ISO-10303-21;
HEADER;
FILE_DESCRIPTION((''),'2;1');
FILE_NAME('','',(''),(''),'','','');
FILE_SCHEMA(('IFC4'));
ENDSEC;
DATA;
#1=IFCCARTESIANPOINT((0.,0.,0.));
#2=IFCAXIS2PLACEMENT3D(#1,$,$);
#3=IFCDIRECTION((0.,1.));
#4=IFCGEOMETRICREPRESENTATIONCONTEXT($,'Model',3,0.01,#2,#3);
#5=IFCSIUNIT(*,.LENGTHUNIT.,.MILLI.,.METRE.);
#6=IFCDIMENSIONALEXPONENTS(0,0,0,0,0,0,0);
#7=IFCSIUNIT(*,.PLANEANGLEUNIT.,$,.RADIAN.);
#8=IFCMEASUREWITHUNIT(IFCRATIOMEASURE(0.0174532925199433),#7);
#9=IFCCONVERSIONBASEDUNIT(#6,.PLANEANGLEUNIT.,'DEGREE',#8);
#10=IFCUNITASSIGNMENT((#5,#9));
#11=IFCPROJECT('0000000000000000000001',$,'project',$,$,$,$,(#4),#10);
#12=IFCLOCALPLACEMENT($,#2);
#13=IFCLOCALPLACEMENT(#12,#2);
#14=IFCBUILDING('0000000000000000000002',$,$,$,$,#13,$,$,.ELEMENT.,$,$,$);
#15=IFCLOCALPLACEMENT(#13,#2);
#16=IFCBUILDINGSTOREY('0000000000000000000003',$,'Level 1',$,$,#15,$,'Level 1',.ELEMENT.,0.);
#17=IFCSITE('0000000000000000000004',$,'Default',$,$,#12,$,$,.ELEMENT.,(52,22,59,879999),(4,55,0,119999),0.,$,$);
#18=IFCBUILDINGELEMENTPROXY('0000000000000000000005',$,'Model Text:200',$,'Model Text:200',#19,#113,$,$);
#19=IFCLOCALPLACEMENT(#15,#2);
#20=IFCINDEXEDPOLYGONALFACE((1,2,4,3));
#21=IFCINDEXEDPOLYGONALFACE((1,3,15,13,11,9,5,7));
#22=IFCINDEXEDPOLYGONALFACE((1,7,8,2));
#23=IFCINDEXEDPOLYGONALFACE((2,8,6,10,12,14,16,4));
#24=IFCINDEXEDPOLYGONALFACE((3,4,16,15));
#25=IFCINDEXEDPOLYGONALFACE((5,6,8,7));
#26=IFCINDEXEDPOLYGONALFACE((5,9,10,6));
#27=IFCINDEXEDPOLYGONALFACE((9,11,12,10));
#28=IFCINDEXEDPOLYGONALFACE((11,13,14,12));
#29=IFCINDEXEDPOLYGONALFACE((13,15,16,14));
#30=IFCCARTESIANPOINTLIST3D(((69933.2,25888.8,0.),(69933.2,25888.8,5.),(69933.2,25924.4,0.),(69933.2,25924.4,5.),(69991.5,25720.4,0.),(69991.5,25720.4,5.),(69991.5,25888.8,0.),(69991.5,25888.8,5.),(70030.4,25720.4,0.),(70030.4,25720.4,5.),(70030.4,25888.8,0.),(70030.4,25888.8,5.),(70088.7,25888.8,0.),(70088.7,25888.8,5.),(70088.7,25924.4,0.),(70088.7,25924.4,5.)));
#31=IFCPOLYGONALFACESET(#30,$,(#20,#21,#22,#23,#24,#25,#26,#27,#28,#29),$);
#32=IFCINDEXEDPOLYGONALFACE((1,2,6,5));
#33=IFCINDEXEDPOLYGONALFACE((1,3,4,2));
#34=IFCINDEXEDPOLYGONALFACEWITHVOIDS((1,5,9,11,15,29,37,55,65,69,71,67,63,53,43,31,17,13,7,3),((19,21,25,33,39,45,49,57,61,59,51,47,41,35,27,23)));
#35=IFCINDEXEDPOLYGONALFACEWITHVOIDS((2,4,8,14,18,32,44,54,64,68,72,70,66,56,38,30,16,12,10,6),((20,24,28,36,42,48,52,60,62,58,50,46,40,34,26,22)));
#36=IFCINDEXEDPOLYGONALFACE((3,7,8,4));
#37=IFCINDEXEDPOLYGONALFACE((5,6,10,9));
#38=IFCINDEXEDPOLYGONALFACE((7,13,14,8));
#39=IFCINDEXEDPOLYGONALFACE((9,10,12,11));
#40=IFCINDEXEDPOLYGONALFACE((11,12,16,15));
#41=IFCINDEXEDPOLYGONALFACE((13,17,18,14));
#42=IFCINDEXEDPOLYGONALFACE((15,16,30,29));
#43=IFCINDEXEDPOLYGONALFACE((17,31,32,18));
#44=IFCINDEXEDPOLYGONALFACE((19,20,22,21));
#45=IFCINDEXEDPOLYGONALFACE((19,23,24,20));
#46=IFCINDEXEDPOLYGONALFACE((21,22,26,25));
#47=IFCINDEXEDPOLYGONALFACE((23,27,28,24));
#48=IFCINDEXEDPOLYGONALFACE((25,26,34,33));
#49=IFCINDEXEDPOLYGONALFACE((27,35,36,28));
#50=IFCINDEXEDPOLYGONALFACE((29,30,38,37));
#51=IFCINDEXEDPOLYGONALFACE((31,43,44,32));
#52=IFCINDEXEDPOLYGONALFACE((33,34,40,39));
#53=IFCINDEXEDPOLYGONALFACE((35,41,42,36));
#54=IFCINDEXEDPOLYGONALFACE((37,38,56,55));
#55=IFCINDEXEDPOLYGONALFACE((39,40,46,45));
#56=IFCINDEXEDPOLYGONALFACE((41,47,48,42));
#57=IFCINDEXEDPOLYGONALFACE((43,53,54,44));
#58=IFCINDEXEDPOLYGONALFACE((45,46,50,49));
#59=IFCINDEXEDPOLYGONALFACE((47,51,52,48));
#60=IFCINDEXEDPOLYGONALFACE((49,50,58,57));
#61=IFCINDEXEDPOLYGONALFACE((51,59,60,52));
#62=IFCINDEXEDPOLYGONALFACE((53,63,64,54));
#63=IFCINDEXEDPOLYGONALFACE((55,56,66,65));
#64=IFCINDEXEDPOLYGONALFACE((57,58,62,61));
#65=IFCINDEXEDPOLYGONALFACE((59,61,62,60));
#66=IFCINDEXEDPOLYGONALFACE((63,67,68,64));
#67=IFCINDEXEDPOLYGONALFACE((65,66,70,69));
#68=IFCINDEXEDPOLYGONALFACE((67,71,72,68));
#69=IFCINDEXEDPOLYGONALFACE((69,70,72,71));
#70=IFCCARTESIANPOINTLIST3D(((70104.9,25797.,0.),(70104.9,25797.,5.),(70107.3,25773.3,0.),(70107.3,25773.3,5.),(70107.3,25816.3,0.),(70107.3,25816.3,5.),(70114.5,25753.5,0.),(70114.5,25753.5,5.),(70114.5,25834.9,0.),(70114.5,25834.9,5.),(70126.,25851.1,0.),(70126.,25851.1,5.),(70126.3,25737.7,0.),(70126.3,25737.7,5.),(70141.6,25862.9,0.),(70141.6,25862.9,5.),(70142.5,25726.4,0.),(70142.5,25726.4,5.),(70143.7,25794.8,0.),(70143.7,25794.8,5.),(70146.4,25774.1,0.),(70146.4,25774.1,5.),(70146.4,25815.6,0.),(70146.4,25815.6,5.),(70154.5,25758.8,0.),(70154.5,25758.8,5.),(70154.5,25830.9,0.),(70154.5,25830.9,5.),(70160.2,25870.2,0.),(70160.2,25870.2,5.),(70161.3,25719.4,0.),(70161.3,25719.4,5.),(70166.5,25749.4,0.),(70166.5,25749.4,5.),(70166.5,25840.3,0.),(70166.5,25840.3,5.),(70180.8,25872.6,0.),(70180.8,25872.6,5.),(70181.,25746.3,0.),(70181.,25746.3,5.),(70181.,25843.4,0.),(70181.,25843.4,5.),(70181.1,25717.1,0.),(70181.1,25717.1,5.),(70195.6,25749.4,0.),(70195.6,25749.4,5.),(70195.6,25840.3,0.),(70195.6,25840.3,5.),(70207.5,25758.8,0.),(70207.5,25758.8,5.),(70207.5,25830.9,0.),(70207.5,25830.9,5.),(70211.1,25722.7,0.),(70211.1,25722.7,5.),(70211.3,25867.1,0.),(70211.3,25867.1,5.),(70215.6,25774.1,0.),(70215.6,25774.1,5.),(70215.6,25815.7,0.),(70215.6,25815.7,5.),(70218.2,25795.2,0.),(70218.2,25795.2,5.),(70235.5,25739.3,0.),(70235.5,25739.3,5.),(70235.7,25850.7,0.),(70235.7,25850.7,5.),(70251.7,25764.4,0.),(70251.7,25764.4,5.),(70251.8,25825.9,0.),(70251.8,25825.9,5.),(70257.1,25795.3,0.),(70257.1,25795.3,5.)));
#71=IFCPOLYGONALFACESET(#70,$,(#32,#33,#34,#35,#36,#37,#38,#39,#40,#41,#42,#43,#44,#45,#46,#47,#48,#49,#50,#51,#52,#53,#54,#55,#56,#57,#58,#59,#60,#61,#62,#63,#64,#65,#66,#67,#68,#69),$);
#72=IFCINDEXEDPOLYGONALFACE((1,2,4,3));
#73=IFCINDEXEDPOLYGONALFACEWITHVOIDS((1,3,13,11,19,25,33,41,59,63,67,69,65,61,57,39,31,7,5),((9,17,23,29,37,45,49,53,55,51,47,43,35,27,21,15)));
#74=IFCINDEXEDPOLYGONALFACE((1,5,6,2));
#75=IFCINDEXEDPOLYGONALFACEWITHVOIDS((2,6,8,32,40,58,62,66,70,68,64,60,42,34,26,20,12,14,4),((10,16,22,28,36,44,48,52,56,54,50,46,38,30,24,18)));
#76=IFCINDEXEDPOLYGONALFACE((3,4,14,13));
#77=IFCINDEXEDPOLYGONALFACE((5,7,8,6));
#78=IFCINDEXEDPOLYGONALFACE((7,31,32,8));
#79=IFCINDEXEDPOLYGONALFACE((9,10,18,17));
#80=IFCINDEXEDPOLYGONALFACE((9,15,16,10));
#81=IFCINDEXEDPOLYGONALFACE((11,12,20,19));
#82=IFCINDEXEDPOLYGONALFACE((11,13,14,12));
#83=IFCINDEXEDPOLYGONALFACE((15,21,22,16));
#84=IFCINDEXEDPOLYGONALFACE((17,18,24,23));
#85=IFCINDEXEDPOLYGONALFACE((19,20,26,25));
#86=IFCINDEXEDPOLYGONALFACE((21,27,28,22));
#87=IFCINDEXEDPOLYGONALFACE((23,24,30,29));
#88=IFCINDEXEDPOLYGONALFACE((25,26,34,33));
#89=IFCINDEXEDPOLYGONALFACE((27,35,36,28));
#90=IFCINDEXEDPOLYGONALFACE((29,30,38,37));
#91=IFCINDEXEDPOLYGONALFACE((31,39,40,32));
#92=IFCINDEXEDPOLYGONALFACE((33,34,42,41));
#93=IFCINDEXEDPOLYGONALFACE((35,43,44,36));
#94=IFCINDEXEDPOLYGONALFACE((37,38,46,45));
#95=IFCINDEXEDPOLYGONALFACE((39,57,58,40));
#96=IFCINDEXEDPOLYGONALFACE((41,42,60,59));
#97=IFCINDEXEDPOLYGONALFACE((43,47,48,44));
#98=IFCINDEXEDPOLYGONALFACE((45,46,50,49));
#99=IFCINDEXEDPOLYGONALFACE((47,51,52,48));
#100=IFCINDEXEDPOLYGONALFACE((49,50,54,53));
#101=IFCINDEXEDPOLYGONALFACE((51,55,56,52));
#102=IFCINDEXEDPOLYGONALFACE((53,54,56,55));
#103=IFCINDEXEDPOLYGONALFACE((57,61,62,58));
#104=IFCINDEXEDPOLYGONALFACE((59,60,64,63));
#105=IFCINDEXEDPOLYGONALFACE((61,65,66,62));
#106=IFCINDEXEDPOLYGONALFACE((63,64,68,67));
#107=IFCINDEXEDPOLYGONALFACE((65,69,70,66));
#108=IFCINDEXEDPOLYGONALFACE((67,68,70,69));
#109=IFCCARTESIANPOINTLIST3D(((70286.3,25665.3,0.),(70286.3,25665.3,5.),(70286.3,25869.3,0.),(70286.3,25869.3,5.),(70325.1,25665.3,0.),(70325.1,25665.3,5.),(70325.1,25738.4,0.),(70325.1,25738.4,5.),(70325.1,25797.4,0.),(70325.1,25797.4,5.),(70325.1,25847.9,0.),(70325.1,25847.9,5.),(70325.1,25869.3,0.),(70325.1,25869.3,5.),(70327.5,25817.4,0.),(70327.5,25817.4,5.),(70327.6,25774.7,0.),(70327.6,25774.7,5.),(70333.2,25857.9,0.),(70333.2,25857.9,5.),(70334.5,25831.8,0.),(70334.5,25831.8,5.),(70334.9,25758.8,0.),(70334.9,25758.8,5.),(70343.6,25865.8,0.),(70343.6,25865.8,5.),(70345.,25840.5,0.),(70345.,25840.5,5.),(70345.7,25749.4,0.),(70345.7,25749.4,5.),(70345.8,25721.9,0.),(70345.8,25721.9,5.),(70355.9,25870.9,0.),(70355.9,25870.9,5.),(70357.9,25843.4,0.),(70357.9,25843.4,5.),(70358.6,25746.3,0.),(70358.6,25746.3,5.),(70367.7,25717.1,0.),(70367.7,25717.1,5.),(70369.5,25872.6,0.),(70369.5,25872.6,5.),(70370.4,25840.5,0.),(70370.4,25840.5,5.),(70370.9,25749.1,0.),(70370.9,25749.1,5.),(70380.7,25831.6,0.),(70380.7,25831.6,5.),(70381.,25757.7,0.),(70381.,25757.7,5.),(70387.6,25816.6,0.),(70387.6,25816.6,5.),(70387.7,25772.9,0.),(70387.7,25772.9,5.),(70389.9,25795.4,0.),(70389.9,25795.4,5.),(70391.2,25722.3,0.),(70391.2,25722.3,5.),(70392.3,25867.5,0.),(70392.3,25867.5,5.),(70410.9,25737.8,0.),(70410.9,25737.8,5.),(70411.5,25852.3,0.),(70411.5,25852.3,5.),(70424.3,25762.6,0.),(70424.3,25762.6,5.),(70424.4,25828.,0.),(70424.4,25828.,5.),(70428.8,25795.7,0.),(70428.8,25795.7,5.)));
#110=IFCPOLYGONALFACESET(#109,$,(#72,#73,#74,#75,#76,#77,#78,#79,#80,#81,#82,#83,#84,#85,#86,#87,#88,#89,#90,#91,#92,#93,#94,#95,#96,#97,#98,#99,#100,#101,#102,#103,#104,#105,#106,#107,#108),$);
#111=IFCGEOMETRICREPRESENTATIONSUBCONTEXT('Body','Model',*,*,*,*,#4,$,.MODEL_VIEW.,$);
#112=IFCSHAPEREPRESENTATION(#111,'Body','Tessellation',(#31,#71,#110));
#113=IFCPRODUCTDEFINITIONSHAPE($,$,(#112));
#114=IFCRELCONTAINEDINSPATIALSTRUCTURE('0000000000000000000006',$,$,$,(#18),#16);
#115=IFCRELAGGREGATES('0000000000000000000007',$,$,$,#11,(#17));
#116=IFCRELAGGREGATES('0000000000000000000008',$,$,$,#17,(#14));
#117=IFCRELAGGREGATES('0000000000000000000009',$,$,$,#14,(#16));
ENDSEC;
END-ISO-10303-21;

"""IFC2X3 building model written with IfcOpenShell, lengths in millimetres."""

from ifc_helpers import new_model, entity, si_unit, converted_unit, direction, frame, origin, place, context, subcontext, project, spatial, polyline, outline, extrude, element, save


model = new_model("IFC2X3")

# Units and contexts
model_context = context("Model", 3, precision=0.01, world=origin(), true_north=direction((0.0, 1.0)))
body_context = subcontext(model_context, "Body", "Model", "MODEL_VIEW")
ifc_project = project(units=[si_unit("LENGTHUNIT", "METRE", prefix="MILLI"), converted_unit("PLANEANGLEUNIT", "DEGREE", entity("IfcRatioMeasure", 0.0174532925199433), si_unit("PLANEANGLEUNIT", "RADIAN"), dimensions=[0, 0, 0, 0, 0, 0, 0])], contexts=[model_context])

# Site, building, storey
site_placement = place(None, origin())
site = spatial("IfcSite", under=ifc_project, at=site_placement, Name="Default", CompositionType="ELEMENT", RefLatitude=(52, 22, 59, 879999), RefLongitude=(4, 55, 0, 119999), RefElevation=0.0)
building_placement = place(site_placement, origin())
building = spatial("IfcBuilding", under=site, at=building_placement, CompositionType="ELEMENT")
storey_placement = place(building_placement, origin())
storey = spatial("IfcBuildingStorey", under=building, at=storey_placement, Name="Level 1", LongName="Level 1", CompositionType="ELEMENT", Elevation=0.0)

# Building element proxy
proxy_1_placement = place(building_placement, origin())
element("IfcBuildingElementProxy", 1, at=proxy_1_placement, inside=storey, Name="Model Text:200", ObjectType="Model Text:200", context=body_context, shape_type="SweptSolid", body=[
    extrude(outline(polyline([(-19.4, -135.2), (19.4, -135.2), (19.4, 33.2), (77.7, 33.2), (77.7, 68.8), (-77.7, 68.8), (-77.7, 33.2), (-19.4, 33.2), (-19.4, -135.2)])), frame((70010.9, 25855.6, 0.0)), (0.0, 0.0, 1.0), 5.0),
    extrude(outline(polyline([(-8.8, -65.7), (15.1, -65.7), (35.5, -60.5), (52.3, -50.4), (65.3, -35.4), (74.1, -17.3), (78.4, 2.1), (75.9, 32.5), (61.8, 58.5), (38.4, 77.1), (8.3, 85.6), (-22.7, 83.3), (-49.0, 69.9), (-67.8, 47.3), (-76.3, 17.5), (-76.0, -3.3), (-70.7, -22.5), (-60.5, -39.2), (-45.5, -52.3), (-27.7, -61.4), (-8.8, -65.7)]), holes=[polyline([(-2.7, -27.2), (-23.1, -22.5), (-37.5, -12.9), (-45.7, 0.0), (-47.3, 14.8), (-42.7, 28.9), (-32.2, 39.9), (-16.3, 46.3), (4.5, 46.9), (25.1, 42.1), (39.6, 32.6), (47.7, 19.7), (49.4, 5.0), (44.8, -9.2), (34.2, -20.2), (18.2, -26.7), (-2.7, -27.2)])]), frame((70171.1, 25794.9, 0.0), z_axis=(0.0, 0.0, 1.0), x_axis=(0.100608, -0.994926, 0.0)), (0.0, 0.0, 1.0), 5.0),
    extrude(outline(polyline([(-73.1, -75.4), (130.9, -75.4), (130.9, -36.6), (57.8, -36.6), (74.3, -15.9), (79.1, 6.0), (73.9, 29.5), (58.4, 49.2), (33.6, 62.6), (0.5, 67.1), (-31.8, 62.8), (-56.1, 49.8), (-71.3, 30.7), (-76.4, 7.8), (-74.7, -5.8), (-69.6, -18.1), (-61.7, -28.5), (-51.7, -36.6), (-73.1, -36.6), (-73.1, -75.4)]), holes=[polyline([(-1.2, -36.6), (-21.2, -34.2), (-35.6, -27.2), (-44.3, -16.7), (-47.2, -3.8), (-44.3, 8.7), (-35.4, 19.0), (-20.4, 25.9), (0.8, 28.2), (23.3, 26.0), (38.5, 19.3), (47.1, 9.2), (49.9, -3.1), (46.8, -16.0), (37.4, -26.8), (21.5, -34.1), (-1.2, -36.6)])]), frame((70361.7, 25796.2, 0.0), z_axis=(0.0, 0.0, 1.0), x_axis=(0.0, -1.0, 0.0)), (0.0, 0.0, 1.0), 5.0),
])

save(model, "model.ifc")
